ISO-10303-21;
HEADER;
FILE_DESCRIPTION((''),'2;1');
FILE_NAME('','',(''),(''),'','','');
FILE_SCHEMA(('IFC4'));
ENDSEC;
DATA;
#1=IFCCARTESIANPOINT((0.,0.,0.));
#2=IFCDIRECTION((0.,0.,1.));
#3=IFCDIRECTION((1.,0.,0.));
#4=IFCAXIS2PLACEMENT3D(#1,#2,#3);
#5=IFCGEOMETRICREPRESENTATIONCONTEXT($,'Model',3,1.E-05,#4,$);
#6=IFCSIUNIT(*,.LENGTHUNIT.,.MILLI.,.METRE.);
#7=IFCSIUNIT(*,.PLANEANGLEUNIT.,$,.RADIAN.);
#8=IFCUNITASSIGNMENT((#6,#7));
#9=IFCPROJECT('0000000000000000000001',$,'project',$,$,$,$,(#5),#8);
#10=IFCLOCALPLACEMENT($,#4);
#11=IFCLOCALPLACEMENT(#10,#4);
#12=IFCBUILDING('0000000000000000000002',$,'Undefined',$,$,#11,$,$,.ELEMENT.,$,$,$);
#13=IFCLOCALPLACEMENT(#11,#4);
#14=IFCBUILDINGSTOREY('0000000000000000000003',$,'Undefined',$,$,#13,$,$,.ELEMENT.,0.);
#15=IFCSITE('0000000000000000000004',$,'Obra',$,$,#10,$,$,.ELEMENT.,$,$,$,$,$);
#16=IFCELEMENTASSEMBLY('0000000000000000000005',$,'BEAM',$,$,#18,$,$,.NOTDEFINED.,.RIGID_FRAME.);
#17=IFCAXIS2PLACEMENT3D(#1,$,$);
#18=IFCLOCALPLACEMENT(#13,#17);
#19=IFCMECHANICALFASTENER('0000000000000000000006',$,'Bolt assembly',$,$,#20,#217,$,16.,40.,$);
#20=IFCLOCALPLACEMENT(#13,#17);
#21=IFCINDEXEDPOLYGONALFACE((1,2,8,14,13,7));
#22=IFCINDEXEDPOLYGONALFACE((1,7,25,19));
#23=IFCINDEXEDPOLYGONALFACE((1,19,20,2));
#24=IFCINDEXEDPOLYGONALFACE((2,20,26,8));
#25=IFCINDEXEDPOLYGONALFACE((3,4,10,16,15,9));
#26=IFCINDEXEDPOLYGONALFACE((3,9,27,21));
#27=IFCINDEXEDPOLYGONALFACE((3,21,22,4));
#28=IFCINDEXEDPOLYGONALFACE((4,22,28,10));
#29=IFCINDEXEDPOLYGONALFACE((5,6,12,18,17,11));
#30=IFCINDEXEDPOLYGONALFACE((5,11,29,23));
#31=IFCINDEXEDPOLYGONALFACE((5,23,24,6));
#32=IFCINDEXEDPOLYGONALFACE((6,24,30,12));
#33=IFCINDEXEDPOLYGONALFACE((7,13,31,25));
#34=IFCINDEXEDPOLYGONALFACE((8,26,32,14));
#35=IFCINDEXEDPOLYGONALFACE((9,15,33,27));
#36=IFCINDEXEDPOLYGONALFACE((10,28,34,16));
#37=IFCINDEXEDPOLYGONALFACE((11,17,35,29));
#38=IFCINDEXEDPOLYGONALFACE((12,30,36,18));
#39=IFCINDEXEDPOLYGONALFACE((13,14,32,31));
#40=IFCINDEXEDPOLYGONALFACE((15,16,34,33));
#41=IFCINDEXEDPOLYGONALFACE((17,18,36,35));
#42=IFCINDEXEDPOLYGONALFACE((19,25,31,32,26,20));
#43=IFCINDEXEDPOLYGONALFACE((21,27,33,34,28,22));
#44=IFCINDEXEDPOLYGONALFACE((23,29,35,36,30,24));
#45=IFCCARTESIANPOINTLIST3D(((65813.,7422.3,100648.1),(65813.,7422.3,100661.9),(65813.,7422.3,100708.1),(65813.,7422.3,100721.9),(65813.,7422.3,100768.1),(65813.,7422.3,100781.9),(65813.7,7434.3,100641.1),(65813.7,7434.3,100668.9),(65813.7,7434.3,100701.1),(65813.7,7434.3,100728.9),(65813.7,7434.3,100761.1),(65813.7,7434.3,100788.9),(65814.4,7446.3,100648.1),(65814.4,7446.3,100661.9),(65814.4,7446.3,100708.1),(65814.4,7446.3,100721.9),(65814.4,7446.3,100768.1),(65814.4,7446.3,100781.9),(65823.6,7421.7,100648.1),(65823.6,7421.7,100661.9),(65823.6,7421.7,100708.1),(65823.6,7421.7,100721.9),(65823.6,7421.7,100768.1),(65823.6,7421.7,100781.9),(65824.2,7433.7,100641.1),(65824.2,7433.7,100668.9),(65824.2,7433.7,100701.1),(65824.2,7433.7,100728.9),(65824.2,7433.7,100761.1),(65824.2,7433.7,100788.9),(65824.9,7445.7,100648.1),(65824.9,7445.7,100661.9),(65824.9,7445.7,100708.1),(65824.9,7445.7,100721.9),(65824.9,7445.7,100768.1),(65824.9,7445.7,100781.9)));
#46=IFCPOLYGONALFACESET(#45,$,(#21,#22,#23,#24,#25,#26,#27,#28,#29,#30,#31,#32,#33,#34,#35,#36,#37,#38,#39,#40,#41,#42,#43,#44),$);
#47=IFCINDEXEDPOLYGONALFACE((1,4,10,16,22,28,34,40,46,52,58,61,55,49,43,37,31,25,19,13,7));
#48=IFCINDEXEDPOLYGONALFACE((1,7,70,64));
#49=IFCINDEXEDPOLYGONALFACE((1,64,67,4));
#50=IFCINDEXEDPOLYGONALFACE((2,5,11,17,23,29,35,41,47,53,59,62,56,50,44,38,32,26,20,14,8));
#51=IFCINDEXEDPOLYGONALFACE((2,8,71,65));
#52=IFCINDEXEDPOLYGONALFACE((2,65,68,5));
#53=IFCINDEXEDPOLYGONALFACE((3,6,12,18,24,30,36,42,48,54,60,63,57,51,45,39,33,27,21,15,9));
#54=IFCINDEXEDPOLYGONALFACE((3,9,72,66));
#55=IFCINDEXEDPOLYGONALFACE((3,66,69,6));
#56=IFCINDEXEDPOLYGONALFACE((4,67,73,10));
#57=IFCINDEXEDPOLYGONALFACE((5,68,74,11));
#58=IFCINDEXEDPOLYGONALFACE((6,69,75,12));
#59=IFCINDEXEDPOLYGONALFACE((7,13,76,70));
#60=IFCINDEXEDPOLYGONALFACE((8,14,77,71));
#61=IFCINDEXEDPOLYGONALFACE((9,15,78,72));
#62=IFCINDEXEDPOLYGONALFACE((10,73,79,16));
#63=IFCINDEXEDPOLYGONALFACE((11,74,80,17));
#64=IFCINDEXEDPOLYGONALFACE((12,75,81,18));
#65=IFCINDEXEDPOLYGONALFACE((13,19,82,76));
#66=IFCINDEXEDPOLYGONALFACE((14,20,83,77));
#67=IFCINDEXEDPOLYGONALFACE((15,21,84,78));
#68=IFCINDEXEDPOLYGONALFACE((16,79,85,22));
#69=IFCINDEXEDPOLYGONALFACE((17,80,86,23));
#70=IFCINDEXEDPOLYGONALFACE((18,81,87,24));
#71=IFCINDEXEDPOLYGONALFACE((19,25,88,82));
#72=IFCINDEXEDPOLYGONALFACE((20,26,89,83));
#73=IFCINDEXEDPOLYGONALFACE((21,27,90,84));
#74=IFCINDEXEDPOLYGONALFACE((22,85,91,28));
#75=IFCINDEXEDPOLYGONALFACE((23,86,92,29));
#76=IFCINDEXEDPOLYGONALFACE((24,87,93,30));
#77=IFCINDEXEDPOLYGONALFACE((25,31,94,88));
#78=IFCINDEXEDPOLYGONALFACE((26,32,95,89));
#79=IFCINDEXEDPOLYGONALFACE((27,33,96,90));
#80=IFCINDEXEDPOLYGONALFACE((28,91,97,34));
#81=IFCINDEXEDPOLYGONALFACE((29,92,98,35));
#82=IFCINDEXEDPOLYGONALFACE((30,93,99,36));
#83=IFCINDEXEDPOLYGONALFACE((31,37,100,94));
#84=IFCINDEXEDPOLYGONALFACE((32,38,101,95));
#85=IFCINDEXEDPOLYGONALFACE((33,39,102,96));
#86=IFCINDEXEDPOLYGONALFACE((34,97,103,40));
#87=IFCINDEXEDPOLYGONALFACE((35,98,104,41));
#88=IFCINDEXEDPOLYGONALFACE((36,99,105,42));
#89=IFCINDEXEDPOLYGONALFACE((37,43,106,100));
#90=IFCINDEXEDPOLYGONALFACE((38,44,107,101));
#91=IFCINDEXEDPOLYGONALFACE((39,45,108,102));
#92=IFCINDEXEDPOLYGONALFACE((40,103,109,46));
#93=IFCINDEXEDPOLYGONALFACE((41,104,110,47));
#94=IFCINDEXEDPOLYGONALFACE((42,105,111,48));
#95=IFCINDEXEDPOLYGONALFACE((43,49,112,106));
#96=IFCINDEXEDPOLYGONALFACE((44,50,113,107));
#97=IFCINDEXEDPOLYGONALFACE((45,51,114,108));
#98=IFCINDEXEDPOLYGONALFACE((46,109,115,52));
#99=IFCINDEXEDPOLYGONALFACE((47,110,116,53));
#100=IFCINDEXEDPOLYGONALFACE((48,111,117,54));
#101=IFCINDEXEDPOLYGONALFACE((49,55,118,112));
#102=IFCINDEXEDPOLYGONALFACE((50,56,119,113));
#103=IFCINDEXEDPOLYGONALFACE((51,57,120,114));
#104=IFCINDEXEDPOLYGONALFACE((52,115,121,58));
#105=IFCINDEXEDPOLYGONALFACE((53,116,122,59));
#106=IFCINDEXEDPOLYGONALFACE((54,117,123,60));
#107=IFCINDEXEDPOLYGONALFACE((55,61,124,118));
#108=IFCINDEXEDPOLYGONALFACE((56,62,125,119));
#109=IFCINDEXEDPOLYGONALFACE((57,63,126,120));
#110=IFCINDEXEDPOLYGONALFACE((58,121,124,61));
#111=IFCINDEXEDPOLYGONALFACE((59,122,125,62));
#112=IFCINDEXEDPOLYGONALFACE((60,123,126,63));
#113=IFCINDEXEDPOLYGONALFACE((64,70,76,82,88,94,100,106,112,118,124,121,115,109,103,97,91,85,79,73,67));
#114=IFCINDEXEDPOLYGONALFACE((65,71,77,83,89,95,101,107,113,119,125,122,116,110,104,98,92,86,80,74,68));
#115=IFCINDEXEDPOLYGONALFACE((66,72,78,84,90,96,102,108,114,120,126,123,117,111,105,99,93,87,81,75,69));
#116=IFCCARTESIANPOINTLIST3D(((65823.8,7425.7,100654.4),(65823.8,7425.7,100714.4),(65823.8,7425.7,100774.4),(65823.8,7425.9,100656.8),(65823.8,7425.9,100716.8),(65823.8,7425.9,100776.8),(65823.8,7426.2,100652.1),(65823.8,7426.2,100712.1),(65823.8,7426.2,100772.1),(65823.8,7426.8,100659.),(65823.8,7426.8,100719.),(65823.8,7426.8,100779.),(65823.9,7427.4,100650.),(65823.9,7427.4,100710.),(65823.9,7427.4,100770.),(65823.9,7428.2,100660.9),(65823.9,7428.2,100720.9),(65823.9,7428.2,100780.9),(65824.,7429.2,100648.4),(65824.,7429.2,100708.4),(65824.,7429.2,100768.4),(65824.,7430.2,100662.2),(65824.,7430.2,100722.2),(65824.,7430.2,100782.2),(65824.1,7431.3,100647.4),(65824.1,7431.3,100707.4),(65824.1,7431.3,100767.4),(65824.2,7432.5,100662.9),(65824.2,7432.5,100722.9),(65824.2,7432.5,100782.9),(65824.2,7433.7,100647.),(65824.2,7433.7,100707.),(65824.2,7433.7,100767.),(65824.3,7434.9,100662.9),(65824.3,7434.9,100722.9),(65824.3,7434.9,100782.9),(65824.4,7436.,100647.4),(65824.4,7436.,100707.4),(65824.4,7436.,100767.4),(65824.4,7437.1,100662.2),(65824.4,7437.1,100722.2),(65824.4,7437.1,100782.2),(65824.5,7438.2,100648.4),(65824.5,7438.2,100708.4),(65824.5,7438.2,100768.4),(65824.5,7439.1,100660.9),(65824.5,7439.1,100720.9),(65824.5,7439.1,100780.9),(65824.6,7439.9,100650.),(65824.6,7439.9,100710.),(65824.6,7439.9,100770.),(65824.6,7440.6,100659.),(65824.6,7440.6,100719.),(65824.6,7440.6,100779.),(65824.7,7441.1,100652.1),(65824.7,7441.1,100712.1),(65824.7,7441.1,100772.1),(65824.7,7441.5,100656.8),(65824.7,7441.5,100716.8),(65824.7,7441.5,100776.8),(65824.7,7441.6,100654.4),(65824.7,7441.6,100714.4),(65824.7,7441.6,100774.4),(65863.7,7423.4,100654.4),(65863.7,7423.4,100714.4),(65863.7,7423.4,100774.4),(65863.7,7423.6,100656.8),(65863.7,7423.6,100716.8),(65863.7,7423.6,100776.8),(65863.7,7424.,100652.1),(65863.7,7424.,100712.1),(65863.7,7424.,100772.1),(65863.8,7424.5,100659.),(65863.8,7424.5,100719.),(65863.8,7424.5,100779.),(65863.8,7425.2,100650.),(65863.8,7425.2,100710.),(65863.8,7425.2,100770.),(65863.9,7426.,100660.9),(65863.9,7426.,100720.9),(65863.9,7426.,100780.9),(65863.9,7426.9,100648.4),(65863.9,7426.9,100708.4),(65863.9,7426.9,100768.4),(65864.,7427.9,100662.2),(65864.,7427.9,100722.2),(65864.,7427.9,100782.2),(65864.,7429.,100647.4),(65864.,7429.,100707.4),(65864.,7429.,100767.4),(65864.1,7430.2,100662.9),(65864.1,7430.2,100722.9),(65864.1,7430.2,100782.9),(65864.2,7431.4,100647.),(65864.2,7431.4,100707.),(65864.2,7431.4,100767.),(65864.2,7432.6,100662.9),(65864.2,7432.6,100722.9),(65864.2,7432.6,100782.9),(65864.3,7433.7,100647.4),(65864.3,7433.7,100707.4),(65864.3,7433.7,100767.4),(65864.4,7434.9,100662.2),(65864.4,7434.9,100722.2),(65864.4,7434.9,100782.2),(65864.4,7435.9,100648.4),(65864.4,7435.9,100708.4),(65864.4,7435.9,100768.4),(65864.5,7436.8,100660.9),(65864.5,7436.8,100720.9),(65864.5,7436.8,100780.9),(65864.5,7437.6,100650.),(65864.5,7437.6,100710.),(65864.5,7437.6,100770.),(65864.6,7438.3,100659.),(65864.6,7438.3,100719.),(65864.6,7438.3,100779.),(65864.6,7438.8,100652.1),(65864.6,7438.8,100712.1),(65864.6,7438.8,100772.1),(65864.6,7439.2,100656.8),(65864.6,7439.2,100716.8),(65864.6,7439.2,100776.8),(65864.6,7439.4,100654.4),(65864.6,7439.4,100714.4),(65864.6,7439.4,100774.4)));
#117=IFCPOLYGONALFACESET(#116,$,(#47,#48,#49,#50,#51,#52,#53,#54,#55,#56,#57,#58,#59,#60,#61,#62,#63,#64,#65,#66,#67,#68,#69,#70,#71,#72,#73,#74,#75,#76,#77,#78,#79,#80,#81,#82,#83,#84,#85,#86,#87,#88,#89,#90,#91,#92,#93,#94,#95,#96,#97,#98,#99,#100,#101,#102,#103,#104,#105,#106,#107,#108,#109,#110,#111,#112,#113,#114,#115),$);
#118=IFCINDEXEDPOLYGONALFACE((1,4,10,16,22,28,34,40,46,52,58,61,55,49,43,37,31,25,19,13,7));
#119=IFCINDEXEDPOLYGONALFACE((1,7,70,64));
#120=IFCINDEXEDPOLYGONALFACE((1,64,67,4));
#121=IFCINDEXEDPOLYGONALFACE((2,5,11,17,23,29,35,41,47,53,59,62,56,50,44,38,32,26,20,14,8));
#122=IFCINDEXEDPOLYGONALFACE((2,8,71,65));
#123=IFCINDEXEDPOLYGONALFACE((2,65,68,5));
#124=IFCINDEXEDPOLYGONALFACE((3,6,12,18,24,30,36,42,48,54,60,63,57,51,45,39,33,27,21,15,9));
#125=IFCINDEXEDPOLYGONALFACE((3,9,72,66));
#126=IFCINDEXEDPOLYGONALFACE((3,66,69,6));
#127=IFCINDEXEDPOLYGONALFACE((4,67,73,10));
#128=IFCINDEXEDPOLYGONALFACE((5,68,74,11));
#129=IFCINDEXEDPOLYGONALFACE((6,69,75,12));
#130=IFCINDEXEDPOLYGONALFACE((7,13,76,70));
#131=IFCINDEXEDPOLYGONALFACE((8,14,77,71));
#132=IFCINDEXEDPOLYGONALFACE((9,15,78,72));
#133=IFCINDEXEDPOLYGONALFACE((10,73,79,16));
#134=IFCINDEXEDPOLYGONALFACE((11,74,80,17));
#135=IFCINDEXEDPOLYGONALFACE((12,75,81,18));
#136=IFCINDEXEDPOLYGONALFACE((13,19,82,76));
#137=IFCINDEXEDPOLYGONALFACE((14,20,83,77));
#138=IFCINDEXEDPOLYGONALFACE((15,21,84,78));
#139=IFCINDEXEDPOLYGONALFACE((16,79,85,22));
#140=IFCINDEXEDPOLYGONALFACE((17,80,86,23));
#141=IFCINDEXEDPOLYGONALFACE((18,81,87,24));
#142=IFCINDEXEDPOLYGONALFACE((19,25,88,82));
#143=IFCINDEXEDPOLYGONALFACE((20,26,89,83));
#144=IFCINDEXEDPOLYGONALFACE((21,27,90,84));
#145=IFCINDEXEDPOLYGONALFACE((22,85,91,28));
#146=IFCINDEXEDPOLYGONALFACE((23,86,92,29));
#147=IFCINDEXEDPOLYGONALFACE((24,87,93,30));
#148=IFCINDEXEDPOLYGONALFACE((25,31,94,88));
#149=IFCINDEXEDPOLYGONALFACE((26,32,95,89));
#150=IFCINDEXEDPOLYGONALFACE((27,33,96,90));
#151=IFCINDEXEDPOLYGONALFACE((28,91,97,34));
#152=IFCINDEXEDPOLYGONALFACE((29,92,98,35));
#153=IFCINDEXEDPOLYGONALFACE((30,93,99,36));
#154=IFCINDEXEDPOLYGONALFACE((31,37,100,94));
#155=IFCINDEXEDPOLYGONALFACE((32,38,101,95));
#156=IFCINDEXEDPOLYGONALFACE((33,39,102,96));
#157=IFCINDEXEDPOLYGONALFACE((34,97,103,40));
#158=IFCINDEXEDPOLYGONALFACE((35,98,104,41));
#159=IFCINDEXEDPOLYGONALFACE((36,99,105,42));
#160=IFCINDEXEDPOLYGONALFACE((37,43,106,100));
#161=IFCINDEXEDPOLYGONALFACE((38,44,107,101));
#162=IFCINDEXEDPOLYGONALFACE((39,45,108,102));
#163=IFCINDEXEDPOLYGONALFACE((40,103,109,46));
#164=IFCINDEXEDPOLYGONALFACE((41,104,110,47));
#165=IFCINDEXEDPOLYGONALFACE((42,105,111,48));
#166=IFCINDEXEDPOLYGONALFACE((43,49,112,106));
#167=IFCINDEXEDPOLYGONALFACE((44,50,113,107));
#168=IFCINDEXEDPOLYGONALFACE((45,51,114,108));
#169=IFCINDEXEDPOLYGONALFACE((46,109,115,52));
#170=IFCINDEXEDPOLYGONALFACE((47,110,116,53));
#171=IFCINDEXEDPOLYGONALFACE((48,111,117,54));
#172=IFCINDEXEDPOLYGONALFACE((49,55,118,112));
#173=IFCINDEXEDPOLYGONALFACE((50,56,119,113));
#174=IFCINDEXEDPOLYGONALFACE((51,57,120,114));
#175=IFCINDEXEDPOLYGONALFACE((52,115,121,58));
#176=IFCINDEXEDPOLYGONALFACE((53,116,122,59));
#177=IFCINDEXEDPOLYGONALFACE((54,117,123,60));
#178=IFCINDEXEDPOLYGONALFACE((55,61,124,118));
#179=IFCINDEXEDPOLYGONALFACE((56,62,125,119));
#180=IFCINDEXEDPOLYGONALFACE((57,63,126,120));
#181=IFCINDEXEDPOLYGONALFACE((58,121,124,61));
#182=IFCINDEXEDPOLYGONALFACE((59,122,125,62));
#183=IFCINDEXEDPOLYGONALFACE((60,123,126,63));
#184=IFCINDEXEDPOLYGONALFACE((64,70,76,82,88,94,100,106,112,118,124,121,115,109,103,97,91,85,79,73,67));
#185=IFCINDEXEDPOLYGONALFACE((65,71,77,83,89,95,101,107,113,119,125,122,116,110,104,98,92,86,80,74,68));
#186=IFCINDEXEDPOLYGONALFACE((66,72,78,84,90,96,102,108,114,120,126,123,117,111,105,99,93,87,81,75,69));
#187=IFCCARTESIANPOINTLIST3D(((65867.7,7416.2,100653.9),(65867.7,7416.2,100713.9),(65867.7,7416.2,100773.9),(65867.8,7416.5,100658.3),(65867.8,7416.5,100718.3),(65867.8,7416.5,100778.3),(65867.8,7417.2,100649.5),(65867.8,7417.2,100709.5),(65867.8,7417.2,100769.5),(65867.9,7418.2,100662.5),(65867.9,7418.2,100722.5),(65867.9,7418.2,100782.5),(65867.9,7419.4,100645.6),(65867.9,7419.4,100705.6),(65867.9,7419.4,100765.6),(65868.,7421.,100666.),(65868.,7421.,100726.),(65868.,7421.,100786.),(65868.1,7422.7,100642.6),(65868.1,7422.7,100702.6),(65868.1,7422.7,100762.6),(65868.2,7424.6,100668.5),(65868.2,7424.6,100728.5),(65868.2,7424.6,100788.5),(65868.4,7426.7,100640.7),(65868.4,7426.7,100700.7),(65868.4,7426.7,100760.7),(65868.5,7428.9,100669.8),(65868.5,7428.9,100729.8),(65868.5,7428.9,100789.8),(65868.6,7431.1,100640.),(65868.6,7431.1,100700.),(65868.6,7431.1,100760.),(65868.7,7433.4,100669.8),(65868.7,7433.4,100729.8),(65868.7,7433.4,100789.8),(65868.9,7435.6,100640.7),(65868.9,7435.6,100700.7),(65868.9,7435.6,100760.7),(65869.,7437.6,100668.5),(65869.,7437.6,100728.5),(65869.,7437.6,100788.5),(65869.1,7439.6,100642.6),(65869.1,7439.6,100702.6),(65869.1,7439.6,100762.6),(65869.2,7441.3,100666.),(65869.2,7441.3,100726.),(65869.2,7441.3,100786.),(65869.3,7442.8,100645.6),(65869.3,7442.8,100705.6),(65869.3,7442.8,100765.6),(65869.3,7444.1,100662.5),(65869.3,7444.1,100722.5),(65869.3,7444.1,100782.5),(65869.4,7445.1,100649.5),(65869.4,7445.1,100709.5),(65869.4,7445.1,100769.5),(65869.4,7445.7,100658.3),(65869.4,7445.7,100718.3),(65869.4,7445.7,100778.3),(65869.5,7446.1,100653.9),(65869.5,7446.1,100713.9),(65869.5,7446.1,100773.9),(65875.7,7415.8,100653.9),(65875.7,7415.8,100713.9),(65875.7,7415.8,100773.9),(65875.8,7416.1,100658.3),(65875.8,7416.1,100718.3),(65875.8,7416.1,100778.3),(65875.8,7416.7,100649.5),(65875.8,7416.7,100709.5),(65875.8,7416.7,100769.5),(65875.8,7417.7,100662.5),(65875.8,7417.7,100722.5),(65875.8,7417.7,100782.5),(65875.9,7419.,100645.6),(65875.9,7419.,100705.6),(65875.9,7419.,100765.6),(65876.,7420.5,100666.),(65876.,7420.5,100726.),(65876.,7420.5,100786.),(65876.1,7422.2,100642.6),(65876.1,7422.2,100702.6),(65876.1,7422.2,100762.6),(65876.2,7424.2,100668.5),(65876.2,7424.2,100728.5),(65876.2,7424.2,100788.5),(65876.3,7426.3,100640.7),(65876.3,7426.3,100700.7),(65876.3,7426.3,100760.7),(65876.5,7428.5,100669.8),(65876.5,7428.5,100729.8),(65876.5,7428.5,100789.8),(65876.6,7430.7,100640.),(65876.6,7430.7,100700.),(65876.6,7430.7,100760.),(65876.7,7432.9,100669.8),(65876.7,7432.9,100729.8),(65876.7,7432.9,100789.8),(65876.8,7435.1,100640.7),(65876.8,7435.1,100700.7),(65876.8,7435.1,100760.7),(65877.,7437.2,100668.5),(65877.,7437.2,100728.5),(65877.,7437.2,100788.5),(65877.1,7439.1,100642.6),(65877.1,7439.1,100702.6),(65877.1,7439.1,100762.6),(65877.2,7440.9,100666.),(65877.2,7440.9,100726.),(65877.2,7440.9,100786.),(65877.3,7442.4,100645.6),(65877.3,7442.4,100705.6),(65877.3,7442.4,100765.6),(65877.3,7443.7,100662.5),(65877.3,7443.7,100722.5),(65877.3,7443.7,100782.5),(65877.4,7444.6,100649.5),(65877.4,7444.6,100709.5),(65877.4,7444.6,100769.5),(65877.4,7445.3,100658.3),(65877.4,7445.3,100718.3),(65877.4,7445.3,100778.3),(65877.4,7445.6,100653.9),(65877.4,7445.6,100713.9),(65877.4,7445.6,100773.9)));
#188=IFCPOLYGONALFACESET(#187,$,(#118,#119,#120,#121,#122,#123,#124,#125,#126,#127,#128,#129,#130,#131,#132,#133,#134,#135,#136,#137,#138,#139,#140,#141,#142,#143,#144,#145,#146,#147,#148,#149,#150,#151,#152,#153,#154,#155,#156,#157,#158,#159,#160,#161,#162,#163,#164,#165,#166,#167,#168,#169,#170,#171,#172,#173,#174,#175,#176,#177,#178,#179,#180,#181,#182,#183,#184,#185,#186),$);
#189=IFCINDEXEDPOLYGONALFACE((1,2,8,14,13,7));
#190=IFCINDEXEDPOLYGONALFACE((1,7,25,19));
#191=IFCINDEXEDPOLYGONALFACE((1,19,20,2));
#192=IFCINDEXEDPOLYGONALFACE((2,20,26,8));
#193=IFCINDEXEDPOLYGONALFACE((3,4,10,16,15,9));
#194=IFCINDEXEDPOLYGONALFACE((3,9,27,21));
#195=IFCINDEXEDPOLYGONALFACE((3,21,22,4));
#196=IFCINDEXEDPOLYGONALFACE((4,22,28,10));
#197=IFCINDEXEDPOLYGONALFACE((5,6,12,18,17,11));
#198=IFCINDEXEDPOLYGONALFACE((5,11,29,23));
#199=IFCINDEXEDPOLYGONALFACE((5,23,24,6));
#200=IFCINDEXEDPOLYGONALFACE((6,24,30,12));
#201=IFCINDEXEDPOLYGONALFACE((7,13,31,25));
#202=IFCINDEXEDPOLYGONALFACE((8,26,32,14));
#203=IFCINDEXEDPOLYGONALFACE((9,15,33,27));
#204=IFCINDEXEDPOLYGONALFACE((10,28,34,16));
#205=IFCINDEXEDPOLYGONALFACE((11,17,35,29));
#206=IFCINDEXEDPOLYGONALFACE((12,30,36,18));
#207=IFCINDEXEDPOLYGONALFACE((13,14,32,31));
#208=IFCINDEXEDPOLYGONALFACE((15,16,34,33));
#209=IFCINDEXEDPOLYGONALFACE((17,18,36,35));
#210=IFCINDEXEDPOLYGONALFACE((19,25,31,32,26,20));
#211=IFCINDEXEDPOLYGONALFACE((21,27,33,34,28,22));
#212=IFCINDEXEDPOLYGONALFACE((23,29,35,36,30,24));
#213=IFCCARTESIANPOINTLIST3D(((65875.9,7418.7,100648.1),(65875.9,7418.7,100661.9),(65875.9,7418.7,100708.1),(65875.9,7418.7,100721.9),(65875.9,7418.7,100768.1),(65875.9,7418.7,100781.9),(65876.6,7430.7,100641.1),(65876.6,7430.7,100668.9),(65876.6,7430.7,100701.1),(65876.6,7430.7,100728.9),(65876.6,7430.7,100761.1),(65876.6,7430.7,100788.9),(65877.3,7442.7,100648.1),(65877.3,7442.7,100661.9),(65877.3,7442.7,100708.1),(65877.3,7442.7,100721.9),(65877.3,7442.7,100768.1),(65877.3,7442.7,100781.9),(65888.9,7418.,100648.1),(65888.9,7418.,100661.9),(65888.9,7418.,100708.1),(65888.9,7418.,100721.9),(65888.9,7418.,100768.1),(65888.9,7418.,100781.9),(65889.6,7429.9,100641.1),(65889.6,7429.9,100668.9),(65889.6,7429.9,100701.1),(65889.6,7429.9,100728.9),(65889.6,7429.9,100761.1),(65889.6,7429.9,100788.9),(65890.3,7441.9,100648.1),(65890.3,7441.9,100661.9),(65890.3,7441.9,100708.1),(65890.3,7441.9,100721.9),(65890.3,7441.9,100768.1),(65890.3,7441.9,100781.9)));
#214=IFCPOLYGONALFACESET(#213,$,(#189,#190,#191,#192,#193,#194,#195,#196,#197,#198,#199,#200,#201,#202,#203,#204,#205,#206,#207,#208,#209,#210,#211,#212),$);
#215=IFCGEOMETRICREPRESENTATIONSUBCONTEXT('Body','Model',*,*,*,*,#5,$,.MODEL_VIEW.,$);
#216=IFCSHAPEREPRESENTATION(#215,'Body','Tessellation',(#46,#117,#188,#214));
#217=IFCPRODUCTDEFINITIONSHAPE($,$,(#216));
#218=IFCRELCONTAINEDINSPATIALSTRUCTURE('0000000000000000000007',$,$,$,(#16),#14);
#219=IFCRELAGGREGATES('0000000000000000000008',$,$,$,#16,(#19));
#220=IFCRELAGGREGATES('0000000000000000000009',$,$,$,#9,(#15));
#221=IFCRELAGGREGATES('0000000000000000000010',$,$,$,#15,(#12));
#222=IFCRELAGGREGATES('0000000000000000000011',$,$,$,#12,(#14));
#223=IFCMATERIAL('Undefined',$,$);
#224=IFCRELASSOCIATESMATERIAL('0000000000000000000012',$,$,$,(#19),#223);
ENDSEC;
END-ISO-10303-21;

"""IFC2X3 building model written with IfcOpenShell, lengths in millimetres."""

from ifc_helpers import new_model, si_unit, frame, origin_with_axes, origin_2d_with_axis, place, context, subcontext, project, spatial, polyline, circle, outline, extrude, source, transform, mapped, material, element, aggregate, save


model = new_model("IFC2X3")

# Units and contexts
model_context = context("Model", 3, precision=1e-05, world=origin_with_axes())
body_context = subcontext(model_context, "Body", "Model", "MODEL_VIEW")
ifc_project = project(units=[si_unit("LENGTHUNIT", "METRE", prefix="MILLI"), si_unit("PLANEANGLEUNIT", "RADIAN")], contexts=[model_context])

# Site, building, storey
site_placement = place(None, origin_with_axes())
site = spatial("IfcSite", under=ifc_project, at=site_placement, Name="Obra", CompositionType="ELEMENT")
building_placement = place(site_placement, origin_with_axes())
building = spatial("IfcBuilding", under=site, at=building_placement, Name="Undefined", CompositionType="ELEMENT")
storey_placement = place(building_placement, origin_with_axes())
storey = spatial("IfcBuildingStorey", under=building, at=storey_placement, Name="Undefined", CompositionType="ELEMENT", Elevation=0.0)

# Shared definitions
ifc_material_1 = material(Name="Undefined")

# Element assembly
assembly_1_placement = place(storey_placement, origin_with_axes())
assembly_1 = element("IfcElementAssembly", 1, at=assembly_1_placement, inside=storey, Name="BEAM", AssemblyPlace="NOTDEFINED", PredefinedType="RIGID_FRAME")

# Shared definitions
shared_shape_1 = source(origin_with_axes(), body_context, "Body", "SweptSolid", [
    extrude(outline(polyline([(13.9, 0.0), (6.9, 12.0), (-6.9, 12.0), (-13.9, 0.0), (-6.9, -12.0), (6.9, -12.0), (13.9, 0.0)])), frame((0.0, -19.7, 0.0), z_axis=(0.0, 1.0, 0.0), x_axis=(1.0, 0.0, 0.0)), (0.0, 0.0, 1.0), 10.6),
    extrude(circle(Radius=8.0, at=origin_2d_with_axis()), frame((0.0, -9.1, 0.0), z_axis=(0.0, 1.0, 0.0), x_axis=(1.0, 0.0, 0.0)), (0.0, 0.0, 1.0), 40.0),
    extrude(circle(Radius=15.0, at=origin_2d_with_axis()), frame((0.0, 35.3, 0.0), z_axis=(0.0, 1.0, 0.0), x_axis=(1.0, 0.0, 0.0)), (0.0, 0.0, 1.0), 8.0),
    extrude(outline(polyline([(13.9, 0.0), (6.9, 12.0), (-6.9, 12.0), (-13.9, 0.0), (-6.9, -12.0), (6.9, -12.0), (13.9, 0.0)])), frame((0.0, 43.3, 0.0), z_axis=(0.0, 1.0, 0.0), x_axis=(1.0, 0.0, 0.0)), (0.0, 0.0, 1.0), 13.0),
])

# Mechanical fastener
mechanical_fastener_1_placement = place(assembly_1_placement, frame((65836.2, 7483.1, 100835.0), z_axis=(-0.05711, -0.998368, 0.0), x_axis=(0.0, 0.0, -1.0)))
mechanical_fastener_1 = element("IfcMechanicalFastener", 2, at=mechanical_fastener_1_placement, material=ifc_material_1, Name="Bolt assembly", NominalDiameter=16.0, NominalLength=40.0, context=body_context, shape_type="MappedRepresentation", body=[
    mapped(shared_shape_1, transform((60.0, 0.0, 50.0))),
    mapped(shared_shape_1, transform((120.0, 0.0, 50.0))),
    mapped(shared_shape_1, transform((180.0, 0.0, 50.0))),
])
aggregate(assembly_1, [mechanical_fastener_1])

save(model, "model.ifc")
